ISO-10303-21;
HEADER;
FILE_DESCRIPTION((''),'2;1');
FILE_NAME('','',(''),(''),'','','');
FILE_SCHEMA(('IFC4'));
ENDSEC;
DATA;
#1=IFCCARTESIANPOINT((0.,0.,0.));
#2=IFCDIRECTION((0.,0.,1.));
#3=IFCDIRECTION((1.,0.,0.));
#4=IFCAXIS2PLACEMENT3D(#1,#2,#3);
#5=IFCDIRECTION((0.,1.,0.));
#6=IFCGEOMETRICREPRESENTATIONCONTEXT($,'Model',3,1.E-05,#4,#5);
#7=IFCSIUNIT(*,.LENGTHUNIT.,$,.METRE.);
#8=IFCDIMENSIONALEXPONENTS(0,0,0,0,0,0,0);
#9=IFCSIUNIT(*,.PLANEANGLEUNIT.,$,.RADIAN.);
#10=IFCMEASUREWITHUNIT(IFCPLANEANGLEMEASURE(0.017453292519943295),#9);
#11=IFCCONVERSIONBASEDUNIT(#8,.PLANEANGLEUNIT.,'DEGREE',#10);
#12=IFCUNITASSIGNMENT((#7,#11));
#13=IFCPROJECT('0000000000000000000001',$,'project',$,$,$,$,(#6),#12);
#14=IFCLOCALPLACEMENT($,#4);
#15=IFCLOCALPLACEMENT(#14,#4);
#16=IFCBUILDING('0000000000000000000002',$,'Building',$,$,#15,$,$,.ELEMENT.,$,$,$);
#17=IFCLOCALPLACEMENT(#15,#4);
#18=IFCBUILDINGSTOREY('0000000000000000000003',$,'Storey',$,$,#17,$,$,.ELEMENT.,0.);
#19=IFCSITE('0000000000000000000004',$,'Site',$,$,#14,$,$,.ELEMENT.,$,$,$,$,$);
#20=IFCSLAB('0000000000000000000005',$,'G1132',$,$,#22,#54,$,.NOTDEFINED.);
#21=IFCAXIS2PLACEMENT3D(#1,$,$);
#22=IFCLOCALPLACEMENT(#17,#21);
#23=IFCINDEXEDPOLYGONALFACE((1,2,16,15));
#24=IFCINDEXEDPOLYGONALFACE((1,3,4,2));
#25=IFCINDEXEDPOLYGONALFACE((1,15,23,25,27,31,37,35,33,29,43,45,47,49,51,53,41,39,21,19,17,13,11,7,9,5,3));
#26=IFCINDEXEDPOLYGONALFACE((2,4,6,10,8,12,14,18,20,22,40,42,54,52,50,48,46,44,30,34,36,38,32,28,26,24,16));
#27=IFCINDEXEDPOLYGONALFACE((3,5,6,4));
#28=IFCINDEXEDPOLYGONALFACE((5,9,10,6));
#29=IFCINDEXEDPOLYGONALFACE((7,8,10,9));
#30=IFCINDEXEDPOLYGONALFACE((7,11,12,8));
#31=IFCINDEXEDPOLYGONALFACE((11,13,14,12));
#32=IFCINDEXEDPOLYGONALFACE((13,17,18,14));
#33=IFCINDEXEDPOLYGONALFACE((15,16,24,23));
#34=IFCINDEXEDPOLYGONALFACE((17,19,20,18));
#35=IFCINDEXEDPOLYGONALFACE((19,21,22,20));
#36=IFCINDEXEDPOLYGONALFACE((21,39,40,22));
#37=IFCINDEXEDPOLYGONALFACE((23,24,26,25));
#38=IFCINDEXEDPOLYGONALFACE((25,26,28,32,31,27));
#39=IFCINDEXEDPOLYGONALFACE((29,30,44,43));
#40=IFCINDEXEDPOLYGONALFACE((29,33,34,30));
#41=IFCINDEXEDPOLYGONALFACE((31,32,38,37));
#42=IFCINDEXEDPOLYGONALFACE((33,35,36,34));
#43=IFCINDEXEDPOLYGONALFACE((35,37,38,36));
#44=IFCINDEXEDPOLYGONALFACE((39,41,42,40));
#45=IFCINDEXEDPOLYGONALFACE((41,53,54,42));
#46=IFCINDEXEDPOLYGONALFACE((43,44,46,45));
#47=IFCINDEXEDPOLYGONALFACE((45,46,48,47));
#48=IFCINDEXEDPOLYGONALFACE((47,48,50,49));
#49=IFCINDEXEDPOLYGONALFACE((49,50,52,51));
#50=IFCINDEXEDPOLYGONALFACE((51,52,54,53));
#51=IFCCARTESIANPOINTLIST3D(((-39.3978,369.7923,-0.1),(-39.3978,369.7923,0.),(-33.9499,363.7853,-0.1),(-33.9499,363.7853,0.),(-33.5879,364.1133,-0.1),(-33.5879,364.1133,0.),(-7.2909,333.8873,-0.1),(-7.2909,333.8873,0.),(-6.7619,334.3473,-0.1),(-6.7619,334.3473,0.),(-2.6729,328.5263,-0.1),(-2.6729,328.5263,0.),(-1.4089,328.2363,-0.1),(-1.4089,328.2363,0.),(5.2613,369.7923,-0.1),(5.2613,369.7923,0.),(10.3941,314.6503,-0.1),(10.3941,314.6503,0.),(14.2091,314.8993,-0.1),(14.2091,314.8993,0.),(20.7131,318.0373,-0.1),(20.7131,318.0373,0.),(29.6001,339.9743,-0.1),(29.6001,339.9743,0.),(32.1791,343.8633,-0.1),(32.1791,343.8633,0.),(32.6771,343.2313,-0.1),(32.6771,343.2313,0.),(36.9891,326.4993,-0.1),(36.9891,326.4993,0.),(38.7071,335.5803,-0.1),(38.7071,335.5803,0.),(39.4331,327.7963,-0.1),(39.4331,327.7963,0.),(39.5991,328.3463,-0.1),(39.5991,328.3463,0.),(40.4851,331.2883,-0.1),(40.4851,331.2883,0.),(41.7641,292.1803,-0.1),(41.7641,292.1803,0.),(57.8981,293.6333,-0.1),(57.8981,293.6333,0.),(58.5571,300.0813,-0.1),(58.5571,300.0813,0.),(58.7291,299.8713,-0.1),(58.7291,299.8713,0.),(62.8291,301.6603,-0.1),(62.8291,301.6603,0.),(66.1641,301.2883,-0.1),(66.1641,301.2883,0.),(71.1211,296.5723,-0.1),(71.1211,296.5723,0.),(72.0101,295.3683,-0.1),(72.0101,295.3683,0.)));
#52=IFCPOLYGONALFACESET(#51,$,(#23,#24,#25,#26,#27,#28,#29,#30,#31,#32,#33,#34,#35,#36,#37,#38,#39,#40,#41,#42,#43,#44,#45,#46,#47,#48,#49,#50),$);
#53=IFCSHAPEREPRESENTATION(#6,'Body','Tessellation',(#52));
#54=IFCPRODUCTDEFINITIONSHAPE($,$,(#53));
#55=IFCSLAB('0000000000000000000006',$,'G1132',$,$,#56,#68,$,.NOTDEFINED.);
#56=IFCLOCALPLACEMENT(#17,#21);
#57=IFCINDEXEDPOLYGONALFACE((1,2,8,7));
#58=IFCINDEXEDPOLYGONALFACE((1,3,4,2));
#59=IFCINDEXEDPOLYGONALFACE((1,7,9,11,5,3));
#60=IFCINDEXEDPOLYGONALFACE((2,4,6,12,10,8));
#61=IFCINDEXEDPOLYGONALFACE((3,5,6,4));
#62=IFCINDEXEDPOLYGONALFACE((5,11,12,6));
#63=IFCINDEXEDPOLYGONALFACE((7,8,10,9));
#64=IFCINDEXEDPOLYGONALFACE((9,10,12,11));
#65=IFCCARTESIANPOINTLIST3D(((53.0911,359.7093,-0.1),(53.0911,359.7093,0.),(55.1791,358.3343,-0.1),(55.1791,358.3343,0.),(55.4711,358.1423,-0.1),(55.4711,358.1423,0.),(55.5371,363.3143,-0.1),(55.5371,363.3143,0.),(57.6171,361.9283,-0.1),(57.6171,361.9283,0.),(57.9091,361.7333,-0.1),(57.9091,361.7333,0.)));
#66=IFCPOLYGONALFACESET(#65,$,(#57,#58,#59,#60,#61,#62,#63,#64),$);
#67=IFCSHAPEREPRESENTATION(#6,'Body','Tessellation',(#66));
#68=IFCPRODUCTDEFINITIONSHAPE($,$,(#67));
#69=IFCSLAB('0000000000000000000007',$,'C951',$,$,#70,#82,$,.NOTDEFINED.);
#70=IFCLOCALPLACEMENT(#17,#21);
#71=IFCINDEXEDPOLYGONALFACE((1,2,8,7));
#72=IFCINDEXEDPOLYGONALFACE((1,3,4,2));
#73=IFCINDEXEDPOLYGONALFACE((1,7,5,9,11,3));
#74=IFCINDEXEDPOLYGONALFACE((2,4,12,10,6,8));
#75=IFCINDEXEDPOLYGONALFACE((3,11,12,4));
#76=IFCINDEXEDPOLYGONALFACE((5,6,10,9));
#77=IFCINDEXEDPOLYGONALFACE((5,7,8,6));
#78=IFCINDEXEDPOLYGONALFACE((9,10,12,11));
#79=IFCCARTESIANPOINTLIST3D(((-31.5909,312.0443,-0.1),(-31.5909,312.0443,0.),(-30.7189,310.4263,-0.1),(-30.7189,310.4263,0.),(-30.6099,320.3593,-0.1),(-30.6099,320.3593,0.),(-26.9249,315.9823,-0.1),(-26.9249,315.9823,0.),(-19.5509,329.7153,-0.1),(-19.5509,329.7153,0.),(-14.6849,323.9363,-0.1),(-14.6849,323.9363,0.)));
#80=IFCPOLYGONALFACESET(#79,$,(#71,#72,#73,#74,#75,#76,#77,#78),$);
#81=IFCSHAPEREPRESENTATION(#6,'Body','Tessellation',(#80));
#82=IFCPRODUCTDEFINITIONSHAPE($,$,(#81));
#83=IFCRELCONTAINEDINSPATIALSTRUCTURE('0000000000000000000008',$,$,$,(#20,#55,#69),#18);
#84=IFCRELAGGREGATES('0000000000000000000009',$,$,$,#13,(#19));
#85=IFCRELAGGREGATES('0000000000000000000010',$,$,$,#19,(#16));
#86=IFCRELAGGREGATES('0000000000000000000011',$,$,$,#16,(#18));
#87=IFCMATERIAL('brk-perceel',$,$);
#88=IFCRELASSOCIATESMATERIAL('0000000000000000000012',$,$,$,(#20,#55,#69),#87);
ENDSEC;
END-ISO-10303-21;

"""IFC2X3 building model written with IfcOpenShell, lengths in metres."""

from ifc_helpers import new_model, entity, si_unit, converted_unit, direction, frame, origin_with_axes, place, context, project, spatial, polyline, outline, extrude, material, element, save


model = new_model("IFC2X3")

# Units and contexts
model_context = context("Model", 3, precision=1e-05, world=origin_with_axes(), true_north=direction((0.0, 1.0, 0.0)))
ifc_project = project(units=[si_unit("LENGTHUNIT", "METRE"), converted_unit("PLANEANGLEUNIT", "DEGREE", entity("IfcPlaneAngleMeasure", 0.017453292519943295), si_unit("PLANEANGLEUNIT", "RADIAN"), dimensions=[0, 0, 0, 0, 0, 0, 0])], contexts=[model_context])

# Site, building, storey
site_placement = place(None, origin_with_axes())
site = spatial("IfcSite", under=ifc_project, at=site_placement, Name="Site", CompositionType="ELEMENT")
building_placement = place(site_placement, origin_with_axes())
building = spatial("IfcBuilding", under=site, at=building_placement, Name="Building", CompositionType="ELEMENT")
storey_placement = place(building_placement, origin_with_axes())
storey = spatial("IfcBuildingStorey", under=building, at=storey_placement, Name="Storey", CompositionType="ELEMENT", Elevation=0.0)

# Slabs
ifc_material = material(Name="brk-perceel")
slab_1_placement = place(storey_placement, frame((0.0, 0.0, -0.1), z_axis=(0.0, 0.0, 1.0), x_axis=(1.0, 0.0, 0.0)))
element("IfcSlab", 1, at=slab_1_placement, inside=storey, material=ifc_material, Name="G1132", PredefinedType="NOTDEFINED", context=model_context, shape_type="SweptSolid", body=[
    extrude(outline(polyline([(29.6001, 339.9743), (32.1791, 343.8633), (32.6771, 343.2313), (38.7071, 335.5803), (40.4851, 331.2883), (39.5991, 328.3463), (39.4331, 327.7963), (36.9891, 326.4993), (58.5571, 300.0813), (58.7291, 299.8713), (62.8291, 301.6603), (66.1641, 301.2883), (71.1211, 296.5723), (72.0101, 295.3683), (57.8981, 293.6333), (41.7641, 292.1803), (20.7131, 318.0373), (14.2091, 314.8993), (10.3941, 314.6503), (-1.4089, 328.2363), (-2.6729, 328.5263), (-7.2909, 333.8873), (-6.7619, 334.3473), (-33.5879, 364.1133), (-33.9499, 363.7853), (-39.3978, 369.7923), (5.2613, 369.7923), (29.6001, 339.9743)])), origin_with_axes(), (0.0, 0.0, 1.0), 0.1),
])
slab_2_placement = place(storey_placement, frame((0.0, 0.0, -0.1), z_axis=(0.0, 0.0, 1.0), x_axis=(1.0, 0.0, 0.0)))
element("IfcSlab", 2, at=slab_2_placement, inside=storey, material=ifc_material, Name="G1132", PredefinedType="NOTDEFINED", context=model_context, shape_type="SweptSolid", body=[
    extrude(outline(polyline([(57.6171, 361.9283), (57.9091, 361.7333), (55.4711, 358.1423), (55.1791, 358.3343), (53.0911, 359.7093), (55.5371, 363.3143), (57.6171, 361.9283)])), origin_with_axes(), (0.0, 0.0, 1.0), 0.1),
])
slab_3_placement = place(storey_placement, frame((0.0, 0.0, -0.1), z_axis=(0.0, 0.0, 1.0), x_axis=(1.0, 0.0, 0.0)))
element("IfcSlab", 3, at=slab_3_placement, inside=storey, material=ifc_material, Name="C951", PredefinedType="NOTDEFINED", context=model_context, shape_type="SweptSolid", body=[
    extrude(outline(polyline([(-19.5509, 329.7153), (-14.6849, 323.9363), (-30.7189, 310.4263), (-31.5909, 312.0443), (-26.9249, 315.9823), (-30.6099, 320.3593), (-19.5509, 329.7153)])), origin_with_axes(), (0.0, 0.0, 1.0), 0.1),
])

save(model, "model.ifc")
